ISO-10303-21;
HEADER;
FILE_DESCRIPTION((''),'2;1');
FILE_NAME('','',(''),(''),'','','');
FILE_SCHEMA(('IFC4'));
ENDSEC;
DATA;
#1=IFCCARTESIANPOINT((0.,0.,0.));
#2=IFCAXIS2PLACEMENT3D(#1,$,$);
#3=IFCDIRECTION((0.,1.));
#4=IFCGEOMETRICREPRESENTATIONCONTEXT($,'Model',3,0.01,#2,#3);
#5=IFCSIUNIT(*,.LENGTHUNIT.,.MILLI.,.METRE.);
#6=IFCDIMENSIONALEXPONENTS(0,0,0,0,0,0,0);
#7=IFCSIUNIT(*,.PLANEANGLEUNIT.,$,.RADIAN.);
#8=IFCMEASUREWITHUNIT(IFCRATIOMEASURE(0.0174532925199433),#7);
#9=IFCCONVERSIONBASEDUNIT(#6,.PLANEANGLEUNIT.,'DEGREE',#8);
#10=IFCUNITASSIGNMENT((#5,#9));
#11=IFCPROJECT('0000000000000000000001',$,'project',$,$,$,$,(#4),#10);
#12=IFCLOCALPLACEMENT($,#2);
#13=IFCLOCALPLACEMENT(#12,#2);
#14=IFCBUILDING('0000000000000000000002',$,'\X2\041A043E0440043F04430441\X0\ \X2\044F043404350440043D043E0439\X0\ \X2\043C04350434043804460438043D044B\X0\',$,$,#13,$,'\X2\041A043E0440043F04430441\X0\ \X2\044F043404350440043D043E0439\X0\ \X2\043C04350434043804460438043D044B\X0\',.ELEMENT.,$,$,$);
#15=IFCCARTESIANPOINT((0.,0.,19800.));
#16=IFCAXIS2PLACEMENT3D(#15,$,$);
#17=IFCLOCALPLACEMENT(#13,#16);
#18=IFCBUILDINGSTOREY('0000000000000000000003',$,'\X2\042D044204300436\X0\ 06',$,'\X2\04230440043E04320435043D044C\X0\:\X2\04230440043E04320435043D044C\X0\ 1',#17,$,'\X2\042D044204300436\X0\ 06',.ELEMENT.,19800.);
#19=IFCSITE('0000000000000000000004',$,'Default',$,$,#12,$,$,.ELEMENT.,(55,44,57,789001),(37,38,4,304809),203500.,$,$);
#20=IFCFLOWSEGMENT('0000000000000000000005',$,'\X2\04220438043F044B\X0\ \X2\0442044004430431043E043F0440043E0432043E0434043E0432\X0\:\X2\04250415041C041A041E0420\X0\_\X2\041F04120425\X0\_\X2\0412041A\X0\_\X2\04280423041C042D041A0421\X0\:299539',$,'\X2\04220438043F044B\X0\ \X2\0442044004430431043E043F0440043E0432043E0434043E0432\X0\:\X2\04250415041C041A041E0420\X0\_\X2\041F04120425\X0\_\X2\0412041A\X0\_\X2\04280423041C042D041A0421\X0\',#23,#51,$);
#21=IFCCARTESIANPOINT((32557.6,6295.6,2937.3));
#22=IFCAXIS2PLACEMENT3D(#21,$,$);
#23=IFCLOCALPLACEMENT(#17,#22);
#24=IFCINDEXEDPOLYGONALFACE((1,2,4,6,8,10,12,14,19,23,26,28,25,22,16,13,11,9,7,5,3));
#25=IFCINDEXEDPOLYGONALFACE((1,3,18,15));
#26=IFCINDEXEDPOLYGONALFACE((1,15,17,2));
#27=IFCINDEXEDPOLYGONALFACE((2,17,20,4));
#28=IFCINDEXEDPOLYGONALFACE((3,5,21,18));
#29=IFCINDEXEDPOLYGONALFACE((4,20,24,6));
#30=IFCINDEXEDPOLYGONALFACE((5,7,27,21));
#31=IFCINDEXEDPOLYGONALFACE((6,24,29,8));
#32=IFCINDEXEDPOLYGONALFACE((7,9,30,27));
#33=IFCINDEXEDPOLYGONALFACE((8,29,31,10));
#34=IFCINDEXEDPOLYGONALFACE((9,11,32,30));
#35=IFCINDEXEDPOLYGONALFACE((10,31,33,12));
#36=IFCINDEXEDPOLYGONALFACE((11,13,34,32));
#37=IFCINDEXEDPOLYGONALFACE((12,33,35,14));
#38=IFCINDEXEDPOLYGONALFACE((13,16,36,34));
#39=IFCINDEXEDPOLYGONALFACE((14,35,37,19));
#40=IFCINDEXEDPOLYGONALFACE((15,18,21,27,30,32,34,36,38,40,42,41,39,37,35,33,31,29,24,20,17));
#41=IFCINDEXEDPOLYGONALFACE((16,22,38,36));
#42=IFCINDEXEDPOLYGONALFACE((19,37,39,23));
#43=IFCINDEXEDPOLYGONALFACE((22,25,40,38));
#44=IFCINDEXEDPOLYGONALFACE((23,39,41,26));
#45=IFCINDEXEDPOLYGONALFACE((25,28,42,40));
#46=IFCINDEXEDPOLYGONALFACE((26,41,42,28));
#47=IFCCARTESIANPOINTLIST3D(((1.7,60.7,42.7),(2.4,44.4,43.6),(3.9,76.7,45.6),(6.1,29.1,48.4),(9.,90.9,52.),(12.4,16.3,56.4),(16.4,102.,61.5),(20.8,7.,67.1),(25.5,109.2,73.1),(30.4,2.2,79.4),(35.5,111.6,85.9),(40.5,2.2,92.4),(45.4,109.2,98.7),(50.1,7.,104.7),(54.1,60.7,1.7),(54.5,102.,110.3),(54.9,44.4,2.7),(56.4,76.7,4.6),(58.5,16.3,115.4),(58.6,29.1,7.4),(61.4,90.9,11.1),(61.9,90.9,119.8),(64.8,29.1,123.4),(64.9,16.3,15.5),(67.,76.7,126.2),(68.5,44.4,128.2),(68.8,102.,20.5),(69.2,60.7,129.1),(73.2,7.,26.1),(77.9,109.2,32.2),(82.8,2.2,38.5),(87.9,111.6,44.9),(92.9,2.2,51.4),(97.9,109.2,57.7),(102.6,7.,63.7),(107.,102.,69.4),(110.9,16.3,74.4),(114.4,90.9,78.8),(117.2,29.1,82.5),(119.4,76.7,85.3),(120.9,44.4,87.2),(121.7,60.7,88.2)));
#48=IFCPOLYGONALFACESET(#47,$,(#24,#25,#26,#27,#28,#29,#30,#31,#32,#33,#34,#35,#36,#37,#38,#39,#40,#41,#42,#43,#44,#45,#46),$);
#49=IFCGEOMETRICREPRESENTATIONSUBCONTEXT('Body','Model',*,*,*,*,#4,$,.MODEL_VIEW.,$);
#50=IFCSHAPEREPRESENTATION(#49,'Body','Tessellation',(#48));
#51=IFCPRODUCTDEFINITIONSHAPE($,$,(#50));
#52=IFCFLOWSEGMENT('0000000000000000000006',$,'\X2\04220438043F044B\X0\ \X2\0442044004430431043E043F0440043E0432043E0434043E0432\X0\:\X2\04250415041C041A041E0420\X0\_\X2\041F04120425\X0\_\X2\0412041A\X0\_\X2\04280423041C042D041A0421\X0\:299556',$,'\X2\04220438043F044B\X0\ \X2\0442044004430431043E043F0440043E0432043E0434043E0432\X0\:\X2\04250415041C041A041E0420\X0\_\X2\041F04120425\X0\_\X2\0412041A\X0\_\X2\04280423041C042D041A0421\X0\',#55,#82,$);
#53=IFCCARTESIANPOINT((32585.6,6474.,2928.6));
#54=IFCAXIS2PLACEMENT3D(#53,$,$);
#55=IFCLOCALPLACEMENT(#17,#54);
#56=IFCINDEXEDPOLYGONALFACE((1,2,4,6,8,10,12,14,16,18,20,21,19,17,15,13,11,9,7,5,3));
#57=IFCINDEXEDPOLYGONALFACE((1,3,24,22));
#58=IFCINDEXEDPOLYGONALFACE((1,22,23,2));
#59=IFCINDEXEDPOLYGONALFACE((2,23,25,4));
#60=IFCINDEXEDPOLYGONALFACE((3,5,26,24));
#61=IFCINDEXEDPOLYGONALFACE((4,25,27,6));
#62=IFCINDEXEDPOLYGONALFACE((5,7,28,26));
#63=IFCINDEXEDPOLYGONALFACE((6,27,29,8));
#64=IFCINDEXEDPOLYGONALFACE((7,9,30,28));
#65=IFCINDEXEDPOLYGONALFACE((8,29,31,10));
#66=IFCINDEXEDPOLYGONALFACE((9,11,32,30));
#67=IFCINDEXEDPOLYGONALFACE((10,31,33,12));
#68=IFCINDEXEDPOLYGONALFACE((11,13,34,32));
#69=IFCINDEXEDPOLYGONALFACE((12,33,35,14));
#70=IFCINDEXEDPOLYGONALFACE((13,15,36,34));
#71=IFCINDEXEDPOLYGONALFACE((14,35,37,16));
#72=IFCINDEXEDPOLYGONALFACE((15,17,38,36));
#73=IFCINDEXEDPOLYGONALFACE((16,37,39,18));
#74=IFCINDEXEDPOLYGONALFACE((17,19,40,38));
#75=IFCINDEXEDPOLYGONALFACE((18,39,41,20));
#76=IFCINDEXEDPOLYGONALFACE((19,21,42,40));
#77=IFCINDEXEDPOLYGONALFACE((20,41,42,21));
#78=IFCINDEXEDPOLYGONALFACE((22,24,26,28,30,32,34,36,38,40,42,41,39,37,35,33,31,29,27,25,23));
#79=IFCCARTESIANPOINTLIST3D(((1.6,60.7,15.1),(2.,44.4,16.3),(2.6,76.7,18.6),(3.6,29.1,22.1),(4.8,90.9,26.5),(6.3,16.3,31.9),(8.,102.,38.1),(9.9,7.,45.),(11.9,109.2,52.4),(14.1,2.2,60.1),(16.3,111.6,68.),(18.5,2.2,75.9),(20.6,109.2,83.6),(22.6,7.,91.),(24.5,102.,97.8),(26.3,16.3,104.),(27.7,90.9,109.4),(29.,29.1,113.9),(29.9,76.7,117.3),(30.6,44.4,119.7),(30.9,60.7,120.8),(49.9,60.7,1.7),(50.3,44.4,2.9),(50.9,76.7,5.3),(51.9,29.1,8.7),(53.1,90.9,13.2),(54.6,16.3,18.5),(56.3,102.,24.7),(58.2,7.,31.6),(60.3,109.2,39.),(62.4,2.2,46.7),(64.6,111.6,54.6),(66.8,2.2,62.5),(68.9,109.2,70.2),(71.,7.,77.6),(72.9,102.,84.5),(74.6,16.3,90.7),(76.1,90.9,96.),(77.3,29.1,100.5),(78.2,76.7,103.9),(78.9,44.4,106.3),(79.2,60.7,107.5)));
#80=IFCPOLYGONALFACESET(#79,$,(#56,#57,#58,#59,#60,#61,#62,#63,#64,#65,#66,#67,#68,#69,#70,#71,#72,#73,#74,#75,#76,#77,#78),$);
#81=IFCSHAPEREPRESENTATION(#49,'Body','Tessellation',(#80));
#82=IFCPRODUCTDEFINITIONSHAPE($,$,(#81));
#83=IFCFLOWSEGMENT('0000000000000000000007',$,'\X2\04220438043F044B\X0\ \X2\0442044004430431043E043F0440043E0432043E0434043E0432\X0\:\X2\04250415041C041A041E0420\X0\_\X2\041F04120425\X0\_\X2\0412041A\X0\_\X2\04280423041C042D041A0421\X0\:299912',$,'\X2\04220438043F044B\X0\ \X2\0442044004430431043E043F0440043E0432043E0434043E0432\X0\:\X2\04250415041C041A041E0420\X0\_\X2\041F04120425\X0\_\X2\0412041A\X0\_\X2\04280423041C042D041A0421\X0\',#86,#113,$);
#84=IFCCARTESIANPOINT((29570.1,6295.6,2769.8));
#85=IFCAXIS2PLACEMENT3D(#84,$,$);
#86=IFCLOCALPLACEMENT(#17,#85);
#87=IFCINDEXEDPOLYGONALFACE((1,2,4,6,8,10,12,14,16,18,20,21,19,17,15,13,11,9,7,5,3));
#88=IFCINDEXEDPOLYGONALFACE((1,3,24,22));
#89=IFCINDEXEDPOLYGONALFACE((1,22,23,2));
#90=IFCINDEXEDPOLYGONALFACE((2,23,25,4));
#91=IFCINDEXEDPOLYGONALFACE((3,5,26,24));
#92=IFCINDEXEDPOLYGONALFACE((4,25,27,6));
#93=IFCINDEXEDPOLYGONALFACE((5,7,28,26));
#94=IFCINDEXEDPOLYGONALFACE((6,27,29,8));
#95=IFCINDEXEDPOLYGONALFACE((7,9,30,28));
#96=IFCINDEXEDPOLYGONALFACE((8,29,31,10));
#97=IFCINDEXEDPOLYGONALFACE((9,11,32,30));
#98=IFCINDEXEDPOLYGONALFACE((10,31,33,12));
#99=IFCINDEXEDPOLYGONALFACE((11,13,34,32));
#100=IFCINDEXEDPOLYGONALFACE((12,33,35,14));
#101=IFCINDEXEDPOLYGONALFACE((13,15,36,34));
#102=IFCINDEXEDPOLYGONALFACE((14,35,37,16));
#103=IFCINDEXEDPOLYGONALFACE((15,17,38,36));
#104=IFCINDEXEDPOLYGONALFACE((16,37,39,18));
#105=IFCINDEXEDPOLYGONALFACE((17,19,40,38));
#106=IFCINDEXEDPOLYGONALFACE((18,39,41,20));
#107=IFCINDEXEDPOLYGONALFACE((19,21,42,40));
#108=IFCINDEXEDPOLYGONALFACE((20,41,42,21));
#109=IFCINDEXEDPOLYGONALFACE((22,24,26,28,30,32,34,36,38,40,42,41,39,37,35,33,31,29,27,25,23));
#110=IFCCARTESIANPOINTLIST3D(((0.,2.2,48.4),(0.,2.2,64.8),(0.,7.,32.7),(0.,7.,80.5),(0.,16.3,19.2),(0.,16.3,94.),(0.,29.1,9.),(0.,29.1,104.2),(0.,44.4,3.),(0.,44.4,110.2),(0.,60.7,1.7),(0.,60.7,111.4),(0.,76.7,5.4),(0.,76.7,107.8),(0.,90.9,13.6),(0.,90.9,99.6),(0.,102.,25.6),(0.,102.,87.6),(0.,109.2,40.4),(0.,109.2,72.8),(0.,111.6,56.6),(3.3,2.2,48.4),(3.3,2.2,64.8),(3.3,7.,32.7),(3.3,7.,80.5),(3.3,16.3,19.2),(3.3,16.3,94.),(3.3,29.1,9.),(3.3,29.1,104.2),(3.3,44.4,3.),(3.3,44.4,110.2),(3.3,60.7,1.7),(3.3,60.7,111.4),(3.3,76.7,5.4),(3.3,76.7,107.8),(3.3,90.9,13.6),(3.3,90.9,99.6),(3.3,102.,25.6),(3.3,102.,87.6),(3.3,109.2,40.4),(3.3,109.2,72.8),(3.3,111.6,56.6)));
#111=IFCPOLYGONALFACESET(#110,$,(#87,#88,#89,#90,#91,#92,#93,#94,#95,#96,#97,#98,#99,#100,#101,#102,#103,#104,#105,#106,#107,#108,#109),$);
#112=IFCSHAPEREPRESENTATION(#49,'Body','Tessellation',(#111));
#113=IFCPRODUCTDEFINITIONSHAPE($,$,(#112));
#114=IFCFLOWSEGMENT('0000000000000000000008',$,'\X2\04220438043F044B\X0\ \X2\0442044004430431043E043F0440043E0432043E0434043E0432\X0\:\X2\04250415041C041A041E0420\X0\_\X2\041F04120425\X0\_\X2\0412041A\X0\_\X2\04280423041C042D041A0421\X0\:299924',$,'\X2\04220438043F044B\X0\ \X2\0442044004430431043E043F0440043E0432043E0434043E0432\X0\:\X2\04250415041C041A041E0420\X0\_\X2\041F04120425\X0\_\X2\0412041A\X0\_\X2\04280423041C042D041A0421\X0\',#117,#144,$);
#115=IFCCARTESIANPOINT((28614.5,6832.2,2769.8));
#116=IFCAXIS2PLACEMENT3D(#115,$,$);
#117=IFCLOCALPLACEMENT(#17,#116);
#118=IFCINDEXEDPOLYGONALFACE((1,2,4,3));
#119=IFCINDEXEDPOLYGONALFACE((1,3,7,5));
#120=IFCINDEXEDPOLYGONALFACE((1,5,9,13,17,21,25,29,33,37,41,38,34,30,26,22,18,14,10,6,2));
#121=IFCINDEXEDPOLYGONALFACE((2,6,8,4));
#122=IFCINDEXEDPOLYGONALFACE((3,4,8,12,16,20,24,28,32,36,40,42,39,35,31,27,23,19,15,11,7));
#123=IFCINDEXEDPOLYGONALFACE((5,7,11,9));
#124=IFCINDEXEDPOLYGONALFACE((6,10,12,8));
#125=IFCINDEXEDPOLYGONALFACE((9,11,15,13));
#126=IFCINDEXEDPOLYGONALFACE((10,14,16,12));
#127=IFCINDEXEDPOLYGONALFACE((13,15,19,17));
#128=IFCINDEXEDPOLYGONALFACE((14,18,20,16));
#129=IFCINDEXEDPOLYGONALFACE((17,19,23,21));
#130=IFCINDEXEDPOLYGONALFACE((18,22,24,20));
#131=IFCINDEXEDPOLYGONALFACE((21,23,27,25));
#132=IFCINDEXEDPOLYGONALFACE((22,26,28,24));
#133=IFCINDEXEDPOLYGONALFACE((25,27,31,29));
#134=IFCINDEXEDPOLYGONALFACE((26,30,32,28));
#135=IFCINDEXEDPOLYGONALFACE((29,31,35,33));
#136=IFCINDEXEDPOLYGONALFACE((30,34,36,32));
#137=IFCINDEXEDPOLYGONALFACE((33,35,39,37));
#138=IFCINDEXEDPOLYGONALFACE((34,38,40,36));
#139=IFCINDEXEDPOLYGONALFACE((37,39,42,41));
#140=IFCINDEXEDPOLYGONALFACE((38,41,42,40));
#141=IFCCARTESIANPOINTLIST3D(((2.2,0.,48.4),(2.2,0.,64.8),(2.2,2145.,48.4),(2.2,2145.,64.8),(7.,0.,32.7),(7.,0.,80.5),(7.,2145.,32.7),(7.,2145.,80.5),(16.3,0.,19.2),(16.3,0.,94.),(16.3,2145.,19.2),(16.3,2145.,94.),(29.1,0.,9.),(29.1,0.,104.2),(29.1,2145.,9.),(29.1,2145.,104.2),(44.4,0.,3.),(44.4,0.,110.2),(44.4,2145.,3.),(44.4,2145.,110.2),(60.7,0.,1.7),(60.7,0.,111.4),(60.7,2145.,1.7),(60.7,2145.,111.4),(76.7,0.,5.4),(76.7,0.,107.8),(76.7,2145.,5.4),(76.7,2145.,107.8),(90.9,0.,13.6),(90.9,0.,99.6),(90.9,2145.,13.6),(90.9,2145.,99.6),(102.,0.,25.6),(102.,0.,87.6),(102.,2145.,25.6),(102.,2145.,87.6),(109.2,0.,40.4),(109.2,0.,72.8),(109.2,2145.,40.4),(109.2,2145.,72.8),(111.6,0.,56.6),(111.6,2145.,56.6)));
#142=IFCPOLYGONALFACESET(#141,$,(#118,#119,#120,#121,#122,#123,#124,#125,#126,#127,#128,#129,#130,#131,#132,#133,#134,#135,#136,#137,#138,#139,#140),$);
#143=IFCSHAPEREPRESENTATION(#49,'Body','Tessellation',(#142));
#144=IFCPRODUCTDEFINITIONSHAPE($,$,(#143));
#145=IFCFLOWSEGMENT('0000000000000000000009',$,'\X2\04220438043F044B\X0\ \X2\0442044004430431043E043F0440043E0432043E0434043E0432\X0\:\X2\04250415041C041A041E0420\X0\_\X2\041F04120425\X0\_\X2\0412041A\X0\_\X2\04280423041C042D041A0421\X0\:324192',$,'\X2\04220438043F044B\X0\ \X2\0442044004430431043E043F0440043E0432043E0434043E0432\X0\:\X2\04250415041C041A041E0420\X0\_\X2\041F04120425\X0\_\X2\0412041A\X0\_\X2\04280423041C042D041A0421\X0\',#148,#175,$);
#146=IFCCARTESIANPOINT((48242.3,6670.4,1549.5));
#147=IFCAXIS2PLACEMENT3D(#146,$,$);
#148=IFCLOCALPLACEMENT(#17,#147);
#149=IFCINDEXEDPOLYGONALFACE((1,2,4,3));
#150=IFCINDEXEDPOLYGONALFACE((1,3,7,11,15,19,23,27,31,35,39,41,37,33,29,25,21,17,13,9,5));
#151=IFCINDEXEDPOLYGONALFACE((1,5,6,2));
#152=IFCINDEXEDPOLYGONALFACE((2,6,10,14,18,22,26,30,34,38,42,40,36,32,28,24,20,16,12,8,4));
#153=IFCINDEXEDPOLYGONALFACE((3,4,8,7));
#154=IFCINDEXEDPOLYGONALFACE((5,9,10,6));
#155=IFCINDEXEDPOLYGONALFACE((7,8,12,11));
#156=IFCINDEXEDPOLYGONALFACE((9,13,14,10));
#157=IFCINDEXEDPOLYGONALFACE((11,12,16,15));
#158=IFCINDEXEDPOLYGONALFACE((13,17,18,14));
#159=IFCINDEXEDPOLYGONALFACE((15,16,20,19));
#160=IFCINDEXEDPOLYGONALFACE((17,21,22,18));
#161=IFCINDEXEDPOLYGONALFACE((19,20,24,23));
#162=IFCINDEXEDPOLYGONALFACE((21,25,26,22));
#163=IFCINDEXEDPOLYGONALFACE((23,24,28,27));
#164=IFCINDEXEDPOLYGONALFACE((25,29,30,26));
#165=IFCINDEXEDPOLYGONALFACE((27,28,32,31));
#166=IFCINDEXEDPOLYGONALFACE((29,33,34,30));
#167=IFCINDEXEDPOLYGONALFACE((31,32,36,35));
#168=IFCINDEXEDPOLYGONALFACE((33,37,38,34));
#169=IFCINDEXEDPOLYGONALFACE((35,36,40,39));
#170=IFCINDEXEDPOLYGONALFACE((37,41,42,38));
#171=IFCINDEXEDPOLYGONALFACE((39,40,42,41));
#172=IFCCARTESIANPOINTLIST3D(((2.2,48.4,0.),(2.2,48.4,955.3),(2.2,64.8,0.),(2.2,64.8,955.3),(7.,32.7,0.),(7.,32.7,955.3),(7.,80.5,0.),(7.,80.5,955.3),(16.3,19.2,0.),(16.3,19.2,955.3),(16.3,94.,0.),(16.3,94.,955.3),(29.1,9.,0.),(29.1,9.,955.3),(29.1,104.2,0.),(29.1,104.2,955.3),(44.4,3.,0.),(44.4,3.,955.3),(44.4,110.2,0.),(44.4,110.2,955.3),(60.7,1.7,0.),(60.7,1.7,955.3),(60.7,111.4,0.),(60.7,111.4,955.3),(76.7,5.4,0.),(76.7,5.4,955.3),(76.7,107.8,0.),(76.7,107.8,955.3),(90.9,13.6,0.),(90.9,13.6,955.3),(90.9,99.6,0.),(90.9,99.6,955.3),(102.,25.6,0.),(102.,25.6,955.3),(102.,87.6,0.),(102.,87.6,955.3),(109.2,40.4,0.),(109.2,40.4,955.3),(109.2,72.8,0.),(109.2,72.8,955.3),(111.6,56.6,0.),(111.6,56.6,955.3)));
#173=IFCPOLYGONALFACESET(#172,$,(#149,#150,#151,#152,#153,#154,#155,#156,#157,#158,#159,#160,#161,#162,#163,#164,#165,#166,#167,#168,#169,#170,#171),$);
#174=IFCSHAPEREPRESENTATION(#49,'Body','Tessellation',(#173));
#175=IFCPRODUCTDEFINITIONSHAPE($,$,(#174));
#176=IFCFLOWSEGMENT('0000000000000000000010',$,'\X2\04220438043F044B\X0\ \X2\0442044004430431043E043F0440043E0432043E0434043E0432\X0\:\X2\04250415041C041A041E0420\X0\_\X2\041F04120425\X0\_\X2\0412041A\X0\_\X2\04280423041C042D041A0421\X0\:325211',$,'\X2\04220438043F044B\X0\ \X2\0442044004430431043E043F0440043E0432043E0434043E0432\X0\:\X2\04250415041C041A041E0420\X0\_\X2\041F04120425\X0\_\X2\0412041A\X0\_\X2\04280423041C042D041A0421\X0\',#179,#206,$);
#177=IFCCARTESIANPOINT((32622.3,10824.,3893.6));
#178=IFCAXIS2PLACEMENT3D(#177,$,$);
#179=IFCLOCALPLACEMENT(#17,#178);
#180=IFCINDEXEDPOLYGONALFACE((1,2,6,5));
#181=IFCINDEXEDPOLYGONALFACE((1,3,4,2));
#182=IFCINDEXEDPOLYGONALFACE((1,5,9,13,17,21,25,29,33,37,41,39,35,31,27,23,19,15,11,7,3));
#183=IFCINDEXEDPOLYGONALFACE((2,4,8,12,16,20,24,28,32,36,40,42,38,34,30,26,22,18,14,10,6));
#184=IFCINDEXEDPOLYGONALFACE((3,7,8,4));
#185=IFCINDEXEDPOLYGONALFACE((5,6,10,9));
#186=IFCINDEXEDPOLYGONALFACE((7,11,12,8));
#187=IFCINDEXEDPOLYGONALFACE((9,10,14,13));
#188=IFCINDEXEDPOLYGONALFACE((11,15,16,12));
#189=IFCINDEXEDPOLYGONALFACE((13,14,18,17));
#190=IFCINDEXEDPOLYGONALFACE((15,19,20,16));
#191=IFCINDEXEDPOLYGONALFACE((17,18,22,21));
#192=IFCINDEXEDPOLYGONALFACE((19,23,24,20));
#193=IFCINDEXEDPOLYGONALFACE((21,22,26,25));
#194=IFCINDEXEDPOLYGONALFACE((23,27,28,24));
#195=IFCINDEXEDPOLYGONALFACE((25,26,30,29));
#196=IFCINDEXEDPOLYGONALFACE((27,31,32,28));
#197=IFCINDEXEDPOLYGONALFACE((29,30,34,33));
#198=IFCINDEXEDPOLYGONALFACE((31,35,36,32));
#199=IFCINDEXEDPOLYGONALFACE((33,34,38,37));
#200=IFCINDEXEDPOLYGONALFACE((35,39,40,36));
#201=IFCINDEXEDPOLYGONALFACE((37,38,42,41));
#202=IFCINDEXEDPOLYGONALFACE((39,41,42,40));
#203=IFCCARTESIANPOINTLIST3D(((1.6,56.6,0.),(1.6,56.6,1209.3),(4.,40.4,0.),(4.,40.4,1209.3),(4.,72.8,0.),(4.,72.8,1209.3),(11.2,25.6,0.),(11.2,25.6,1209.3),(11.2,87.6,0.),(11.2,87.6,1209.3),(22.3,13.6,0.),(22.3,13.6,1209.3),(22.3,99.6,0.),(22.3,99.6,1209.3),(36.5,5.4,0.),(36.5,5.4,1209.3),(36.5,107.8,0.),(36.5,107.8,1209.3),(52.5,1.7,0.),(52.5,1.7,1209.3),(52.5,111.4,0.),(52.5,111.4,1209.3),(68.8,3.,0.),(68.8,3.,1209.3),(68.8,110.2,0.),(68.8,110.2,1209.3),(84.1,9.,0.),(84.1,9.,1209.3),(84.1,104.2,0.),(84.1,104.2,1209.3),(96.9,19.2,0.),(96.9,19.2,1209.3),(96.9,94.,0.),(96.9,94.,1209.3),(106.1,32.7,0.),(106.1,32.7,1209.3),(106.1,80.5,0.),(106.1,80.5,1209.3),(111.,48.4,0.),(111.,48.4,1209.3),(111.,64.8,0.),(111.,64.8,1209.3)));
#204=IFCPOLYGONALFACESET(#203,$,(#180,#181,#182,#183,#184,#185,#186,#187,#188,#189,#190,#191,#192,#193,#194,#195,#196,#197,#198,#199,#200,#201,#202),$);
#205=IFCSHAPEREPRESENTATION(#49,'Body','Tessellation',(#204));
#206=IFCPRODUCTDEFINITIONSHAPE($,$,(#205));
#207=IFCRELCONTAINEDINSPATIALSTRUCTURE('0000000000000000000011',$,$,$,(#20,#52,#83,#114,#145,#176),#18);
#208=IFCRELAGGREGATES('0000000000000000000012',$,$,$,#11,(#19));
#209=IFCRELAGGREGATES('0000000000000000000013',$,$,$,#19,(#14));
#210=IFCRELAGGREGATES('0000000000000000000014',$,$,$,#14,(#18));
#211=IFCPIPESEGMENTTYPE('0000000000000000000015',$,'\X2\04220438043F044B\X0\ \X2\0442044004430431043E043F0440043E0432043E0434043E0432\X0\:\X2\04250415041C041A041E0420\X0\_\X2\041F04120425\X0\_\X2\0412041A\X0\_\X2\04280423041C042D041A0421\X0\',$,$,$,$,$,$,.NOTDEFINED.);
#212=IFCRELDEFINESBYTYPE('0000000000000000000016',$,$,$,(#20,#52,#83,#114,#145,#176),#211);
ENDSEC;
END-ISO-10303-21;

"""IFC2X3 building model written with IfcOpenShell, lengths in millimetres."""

from ifc_helpers import new_model, entity, si_unit, converted_unit, direction, frame, frame_2d, origin, origin_2d_with_axis, place, context, subcontext, project, spatial, circle, extrude, type_object, element, save


model = new_model("IFC2X3")

# Units and contexts
model_context = context("Model", 3, precision=0.01, world=origin(), true_north=direction((0.0, 1.0)))
body_context = subcontext(model_context, "Body", "Model", "MODEL_VIEW")
ifc_project = project(units=[si_unit("LENGTHUNIT", "METRE", prefix="MILLI"), converted_unit("PLANEANGLEUNIT", "DEGREE", entity("IfcRatioMeasure", 0.0174532925199433), si_unit("PLANEANGLEUNIT", "RADIAN"), dimensions=[0, 0, 0, 0, 0, 0, 0])], contexts=[model_context])

# Site, building, storey
site_placement = place(None, frame((0.0, 0.0, 0.0)))
site = spatial("IfcSite", under=ifc_project, at=site_placement, Name="Default", CompositionType="ELEMENT", RefLatitude=(55, 44, 57, 789001), RefLongitude=(37, 38, 4, 304809), RefElevation=203500.0)
building_placement = place(site_placement, origin())
building = spatial("IfcBuilding", under=site, at=building_placement, Name="Корпус ядерной медицины", LongName="Корпус ядерной медицины", CompositionType="ELEMENT")
storey_placement = place(building_placement, frame((0.0, 0.0, 19800.0)))
storey = spatial("IfcBuildingStorey", under=building, at=storey_placement, Name="Этаж 06", ObjectType="Уровень:Уровень 1", LongName="Этаж 06", CompositionType="ELEMENT", Elevation=19800.0)

# Flow segments
pipe_segment_type = type_object("IfcPipeSegmentType", Name="Типы трубопроводов:ХЕМКОР_ПВХ_ВК_ШУМЭКС", PredefinedType="NOTDEFINED")
flow_segment_1_placement = place(storey_placement, frame((32557.6, 6295.6, 2937.3)))
element("IfcFlowSegment", 1, at=flow_segment_1_placement, inside=storey, type_object=pipe_segment_type, Name="Типы трубопроводов:ХЕМКОР_ПВХ_ВК_ШУМЭКС:299539", ObjectType="Типы трубопроводов:ХЕМКОР_ПВХ_ВК_ШУМЭКС", context=body_context, shape_type="SweptSolid", body=[
    extrude(circle(Radius=55.0, at=origin_2d_with_axis()), frame((35.5, 56.6, 85.9), z_axis=(0.788022, 0.0, -0.615647), x_axis=(0.0, 1.0, 0.0)), (0.0, 0.0, 1.0), 66.5),
])
flow_segment_2_placement = place(storey_placement, frame((32585.6, 6474.0, 2928.6)))
element("IfcFlowSegment", 2, at=flow_segment_2_placement, inside=storey, type_object=pipe_segment_type, Name="Типы трубопроводов:ХЕМКОР_ПВХ_ВК_ШУМЭКС:299556", ObjectType="Типы трубопроводов:ХЕМКОР_ПВХ_ВК_ШУМЭКС", context=body_context, shape_type="SweptSolid", body=[
    extrude(circle(Radius=55.0, at=origin_2d_with_axis()), frame((64.6, 56.6, 54.6), z_axis=(-0.963736, 0.0, 0.266857), x_axis=(0.0, 1.0, 0.0)), (0.0, 0.0, 1.0), 50.1),
])
flow_segment_3_placement = place(storey_placement, frame((29570.1, 6295.6, 2769.8)))
element("IfcFlowSegment", 3, at=flow_segment_3_placement, inside=storey, type_object=pipe_segment_type, Name="Типы трубопроводов:ХЕМКОР_ПВХ_ВК_ШУМЭКС:299912", ObjectType="Типы трубопроводов:ХЕМКОР_ПВХ_ВК_ШУМЭКС", context=body_context, shape_type="SweptSolid", body=[
    extrude(circle(Radius=55.0, at=origin_2d_with_axis()), frame((0.0, 56.6, 56.6), z_axis=(1.0, 0.0, 0.0), x_axis=(0.0, 1.0, 0.0)), (0.0, 0.0, 1.0), 3.3),
])
flow_segment_4_placement = place(storey_placement, frame((28614.5, 6832.2, 2769.8)))
element("IfcFlowSegment", 4, at=flow_segment_4_placement, inside=storey, type_object=pipe_segment_type, Name="Типы трубопроводов:ХЕМКОР_ПВХ_ВК_ШУМЭКС:299924", ObjectType="Типы трубопроводов:ХЕМКОР_ПВХ_ВК_ШУМЭКС", context=body_context, shape_type="SweptSolid", body=[
    extrude(circle(Radius=55.0, at=origin_2d_with_axis()), frame((56.6, 0.0, 56.6), z_axis=(0.0, 1.0, 0.0), x_axis=(1.0, 0.0, 0.0)), (0.0, 0.0, 1.0), 2145.0),
])
flow_segment_5_placement = place(storey_placement, frame((48242.3, 6670.4, 1549.5)))
element("IfcFlowSegment", 5, at=flow_segment_5_placement, inside=storey, type_object=pipe_segment_type, Name="Типы трубопроводов:ХЕМКОР_ПВХ_ВК_ШУМЭКС:324192", ObjectType="Типы трубопроводов:ХЕМКОР_ПВХ_ВК_ШУМЭКС", context=body_context, shape_type="SweptSolid", body=[
    extrude(circle(Radius=55.0, at=origin_2d_with_axis()), frame((56.6, 56.6, 0.0)), (0.0, 0.0, 1.0), 955.3),
])
flow_segment_6_placement = place(storey_placement, frame((32622.3, 10824.0, 3893.6)))
element("IfcFlowSegment", 6, at=flow_segment_6_placement, inside=storey, type_object=pipe_segment_type, Name="Типы трубопроводов:ХЕМКОР_ПВХ_ВК_ШУМЭКС:325211", ObjectType="Типы трубопроводов:ХЕМКОР_ПВХ_ВК_ШУМЭКС", context=body_context, shape_type="SweptSolid", body=[
    extrude(circle(Radius=55.0, at=frame_2d((0.0, 0.0), x_axis=(1.0, 0.0))), frame((56.6, 56.6, 0.0), z_axis=(0.0, 0.0, 1.0), x_axis=(-1.0, 0.0, 0.0)), (0.0, 0.0, 1.0), 1209.3),
])

save(model, "model.ifc")
